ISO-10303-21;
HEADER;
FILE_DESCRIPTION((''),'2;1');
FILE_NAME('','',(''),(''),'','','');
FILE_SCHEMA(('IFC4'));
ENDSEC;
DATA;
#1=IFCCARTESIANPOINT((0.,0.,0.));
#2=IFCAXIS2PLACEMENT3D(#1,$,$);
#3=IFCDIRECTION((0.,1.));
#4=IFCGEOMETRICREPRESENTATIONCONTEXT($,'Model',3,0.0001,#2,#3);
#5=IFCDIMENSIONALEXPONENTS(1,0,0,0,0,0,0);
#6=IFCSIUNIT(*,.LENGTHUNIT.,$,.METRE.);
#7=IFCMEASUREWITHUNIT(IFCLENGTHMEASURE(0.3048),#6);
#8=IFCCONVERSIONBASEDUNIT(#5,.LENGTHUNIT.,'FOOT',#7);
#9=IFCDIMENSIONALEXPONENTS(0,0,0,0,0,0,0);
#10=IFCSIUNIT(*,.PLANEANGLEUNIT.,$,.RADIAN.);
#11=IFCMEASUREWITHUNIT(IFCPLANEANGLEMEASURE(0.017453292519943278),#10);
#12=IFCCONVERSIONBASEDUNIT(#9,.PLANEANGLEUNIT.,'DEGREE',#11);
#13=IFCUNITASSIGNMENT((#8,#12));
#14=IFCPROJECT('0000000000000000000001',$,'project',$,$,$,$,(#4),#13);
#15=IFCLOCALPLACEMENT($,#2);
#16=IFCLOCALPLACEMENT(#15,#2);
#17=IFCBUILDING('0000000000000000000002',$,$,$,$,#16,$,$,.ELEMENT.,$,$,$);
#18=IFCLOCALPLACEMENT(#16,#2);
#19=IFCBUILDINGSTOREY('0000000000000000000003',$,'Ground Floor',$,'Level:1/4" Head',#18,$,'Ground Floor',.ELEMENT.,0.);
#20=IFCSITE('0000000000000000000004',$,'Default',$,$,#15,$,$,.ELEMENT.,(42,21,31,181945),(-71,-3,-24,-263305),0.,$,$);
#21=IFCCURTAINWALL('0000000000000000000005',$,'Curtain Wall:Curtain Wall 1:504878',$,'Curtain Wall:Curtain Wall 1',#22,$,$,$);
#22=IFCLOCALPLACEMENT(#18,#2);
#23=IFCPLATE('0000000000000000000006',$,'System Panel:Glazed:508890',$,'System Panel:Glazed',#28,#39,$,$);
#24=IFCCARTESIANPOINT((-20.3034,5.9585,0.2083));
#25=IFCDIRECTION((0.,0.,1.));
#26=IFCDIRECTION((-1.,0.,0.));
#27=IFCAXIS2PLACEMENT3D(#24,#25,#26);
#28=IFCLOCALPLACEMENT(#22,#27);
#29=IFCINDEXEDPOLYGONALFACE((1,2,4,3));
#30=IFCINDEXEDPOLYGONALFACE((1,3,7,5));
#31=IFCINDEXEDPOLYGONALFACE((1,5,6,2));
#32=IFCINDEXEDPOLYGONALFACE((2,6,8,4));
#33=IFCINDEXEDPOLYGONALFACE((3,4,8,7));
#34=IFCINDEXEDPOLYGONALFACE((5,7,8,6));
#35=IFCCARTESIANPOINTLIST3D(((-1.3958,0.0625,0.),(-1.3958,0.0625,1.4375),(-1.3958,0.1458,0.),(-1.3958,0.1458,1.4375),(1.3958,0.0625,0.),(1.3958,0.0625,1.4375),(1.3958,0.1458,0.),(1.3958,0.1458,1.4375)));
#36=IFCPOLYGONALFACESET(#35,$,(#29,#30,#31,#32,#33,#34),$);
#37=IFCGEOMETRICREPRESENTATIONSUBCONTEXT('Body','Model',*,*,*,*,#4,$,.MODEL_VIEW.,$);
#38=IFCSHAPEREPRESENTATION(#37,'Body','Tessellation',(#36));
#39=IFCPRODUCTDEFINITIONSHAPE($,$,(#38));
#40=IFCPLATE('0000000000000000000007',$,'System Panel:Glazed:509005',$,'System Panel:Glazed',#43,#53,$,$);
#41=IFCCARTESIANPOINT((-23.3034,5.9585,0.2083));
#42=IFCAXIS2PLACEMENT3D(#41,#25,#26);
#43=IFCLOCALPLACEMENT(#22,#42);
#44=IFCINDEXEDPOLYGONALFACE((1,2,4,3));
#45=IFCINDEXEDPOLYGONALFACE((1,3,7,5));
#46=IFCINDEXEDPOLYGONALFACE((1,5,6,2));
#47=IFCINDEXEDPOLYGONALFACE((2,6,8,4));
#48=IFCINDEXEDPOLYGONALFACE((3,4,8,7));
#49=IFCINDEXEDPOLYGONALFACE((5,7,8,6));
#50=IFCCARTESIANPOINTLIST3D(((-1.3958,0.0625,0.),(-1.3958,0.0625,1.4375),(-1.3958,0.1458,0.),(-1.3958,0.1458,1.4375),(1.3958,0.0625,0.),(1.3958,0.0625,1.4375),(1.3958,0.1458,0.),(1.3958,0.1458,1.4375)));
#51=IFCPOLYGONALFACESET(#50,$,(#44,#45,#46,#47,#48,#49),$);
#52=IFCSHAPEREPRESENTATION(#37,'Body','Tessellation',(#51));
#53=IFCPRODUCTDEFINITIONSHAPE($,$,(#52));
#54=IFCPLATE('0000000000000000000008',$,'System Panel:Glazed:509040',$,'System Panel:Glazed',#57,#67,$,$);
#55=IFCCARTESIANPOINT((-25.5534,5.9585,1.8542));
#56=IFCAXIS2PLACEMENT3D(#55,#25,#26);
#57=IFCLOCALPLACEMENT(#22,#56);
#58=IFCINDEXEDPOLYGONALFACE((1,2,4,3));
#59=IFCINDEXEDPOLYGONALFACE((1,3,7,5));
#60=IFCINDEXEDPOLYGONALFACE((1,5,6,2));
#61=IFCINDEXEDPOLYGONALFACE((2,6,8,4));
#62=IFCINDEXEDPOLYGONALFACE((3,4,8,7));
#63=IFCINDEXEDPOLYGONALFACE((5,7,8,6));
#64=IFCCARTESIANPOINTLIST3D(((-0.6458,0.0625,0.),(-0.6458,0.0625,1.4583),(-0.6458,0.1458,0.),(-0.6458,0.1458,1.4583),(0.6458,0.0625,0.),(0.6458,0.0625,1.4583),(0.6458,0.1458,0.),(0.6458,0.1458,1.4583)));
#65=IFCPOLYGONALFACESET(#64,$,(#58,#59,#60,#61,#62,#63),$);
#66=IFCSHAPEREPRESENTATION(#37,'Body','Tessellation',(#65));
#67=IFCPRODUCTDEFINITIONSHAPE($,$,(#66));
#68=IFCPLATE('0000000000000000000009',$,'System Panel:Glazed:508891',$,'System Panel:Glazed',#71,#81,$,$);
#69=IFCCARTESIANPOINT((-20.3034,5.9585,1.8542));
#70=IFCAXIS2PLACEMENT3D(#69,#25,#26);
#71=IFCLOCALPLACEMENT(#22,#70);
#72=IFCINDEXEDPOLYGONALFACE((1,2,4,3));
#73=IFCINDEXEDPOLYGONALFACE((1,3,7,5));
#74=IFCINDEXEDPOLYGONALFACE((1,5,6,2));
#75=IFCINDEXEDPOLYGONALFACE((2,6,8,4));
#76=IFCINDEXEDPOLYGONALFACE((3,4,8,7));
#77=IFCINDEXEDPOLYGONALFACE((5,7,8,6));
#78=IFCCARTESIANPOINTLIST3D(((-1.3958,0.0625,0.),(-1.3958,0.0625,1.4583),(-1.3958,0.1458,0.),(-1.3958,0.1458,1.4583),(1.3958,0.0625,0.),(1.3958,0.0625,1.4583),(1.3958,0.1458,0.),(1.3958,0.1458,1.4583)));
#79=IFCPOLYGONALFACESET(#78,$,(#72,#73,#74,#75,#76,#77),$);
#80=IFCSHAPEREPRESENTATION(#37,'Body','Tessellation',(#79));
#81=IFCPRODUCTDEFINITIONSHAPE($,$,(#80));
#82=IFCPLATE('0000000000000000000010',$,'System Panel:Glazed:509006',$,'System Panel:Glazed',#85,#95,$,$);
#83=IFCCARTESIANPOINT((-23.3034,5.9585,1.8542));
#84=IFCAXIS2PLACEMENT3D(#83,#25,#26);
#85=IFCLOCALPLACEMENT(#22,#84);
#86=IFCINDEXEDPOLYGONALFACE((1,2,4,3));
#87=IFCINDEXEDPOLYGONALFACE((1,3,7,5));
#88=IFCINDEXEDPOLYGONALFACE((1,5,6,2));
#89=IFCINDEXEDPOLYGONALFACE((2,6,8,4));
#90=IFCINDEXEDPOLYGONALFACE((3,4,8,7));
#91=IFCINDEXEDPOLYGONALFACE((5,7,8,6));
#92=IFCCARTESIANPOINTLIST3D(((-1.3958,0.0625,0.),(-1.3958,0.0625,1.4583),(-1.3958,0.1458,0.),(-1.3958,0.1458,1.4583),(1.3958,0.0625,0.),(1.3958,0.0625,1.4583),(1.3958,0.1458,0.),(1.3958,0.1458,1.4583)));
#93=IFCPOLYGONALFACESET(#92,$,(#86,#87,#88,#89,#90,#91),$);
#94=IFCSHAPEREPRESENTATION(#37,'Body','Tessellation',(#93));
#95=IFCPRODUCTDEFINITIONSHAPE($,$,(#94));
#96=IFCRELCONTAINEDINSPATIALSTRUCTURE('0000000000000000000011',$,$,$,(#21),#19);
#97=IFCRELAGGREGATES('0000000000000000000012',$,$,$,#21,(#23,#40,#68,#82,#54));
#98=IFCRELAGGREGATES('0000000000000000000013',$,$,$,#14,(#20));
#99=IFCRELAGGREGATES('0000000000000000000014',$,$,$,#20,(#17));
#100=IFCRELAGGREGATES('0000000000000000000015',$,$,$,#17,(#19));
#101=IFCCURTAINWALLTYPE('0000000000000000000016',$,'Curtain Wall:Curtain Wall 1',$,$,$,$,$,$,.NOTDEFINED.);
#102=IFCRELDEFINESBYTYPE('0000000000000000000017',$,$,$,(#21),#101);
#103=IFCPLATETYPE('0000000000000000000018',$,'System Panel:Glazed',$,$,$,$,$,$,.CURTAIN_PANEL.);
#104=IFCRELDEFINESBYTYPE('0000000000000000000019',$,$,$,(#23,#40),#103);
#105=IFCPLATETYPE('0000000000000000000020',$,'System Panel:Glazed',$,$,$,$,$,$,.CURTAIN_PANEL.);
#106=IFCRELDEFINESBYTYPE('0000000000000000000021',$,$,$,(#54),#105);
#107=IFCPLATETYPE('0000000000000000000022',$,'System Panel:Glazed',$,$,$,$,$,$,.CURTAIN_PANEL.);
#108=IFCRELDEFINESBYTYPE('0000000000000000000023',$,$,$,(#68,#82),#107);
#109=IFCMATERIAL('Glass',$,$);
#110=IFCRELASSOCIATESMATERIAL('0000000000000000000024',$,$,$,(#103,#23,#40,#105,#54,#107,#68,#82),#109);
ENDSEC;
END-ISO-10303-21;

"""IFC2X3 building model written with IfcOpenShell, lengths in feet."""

from ifc_helpers import new_model, entity, si_unit, converted_unit, direction, frame, frame_2d, origin, place, context, subcontext, project, spatial, rectangle, extrude, source, transform, mapped, material, type_object, type_shapes, element, aggregate, save


model = new_model("IFC2X3")

# Units and contexts
model_context = context("Model", 3, precision=0.0001, world=origin(), true_north=direction((0.0, 1.0)))
body_context = subcontext(model_context, "Body", "Model", "MODEL_VIEW")
ifc_project = project(units=[converted_unit("LENGTHUNIT", "FOOT", entity("IfcLengthMeasure", 0.3048), si_unit("LENGTHUNIT", "METRE"), dimensions=[1, 0, 0, 0, 0, 0, 0]), converted_unit("PLANEANGLEUNIT", "DEGREE", entity("IfcPlaneAngleMeasure", 0.017453292519943278), si_unit("PLANEANGLEUNIT", "RADIAN"), dimensions=[0, 0, 0, 0, 0, 0, 0])], contexts=[model_context])

# Site, building, storey
site_placement = place(None, origin())
site = spatial("IfcSite", under=ifc_project, at=site_placement, Name="Default", CompositionType="ELEMENT", RefLatitude=(42, 21, 31, 181945), RefLongitude=(-71, -3, -24, -263305), RefElevation=0.0)
building_placement = place(site_placement, origin())
building = spatial("IfcBuilding", under=site, at=building_placement, CompositionType="ELEMENT")
storey_placement = place(building_placement, origin())
storey = spatial("IfcBuildingStorey", under=building, at=storey_placement, Name="Ground Floor", ObjectType="Level:1/4\" Head", LongName="Ground Floor", CompositionType="ELEMENT", Elevation=0.0)

# Curtain wall, plates
curtain_wall_type = type_object("IfcCurtainWallType", Name="Curtain Wall:Curtain Wall 1", PredefinedType="NOTDEFINED")
curtain_wall_placement = place(storey_placement, origin())
curtain_wall = element("IfcCurtainWall", 1, at=curtain_wall_placement, inside=storey, type_object=curtain_wall_type, Name="Curtain Wall:Curtain Wall 1:504878", ObjectType="Curtain Wall:Curtain Wall 1")
ifc_material_1 = material(Name="Glass")
plate_type_1 = type_object("IfcPlateType", Name="System Panel:Glazed", PredefinedType="CURTAIN_PANEL", material=ifc_material_1)
shared_shape_1 = source(origin(), body_context, "Body", "SweptSolid", [
    extrude(rectangle(XDim=0.0833, YDim=2.7917, at=frame_2d((0.0, 0.0), x_axis=(1.0, 0.0))), frame((0.0, 0.1042, 0.0), z_axis=(0.0, 0.0, 1.0), x_axis=(0.0, 1.0, 0.0)), (0.0, 0.0, 1.0), 1.4375),
])
type_shapes(plate_type_1, [shared_shape_1])
plate_1_placement = place(curtain_wall_placement, frame((-20.3034, 5.9585, 0.2083), z_axis=(0.0, 0.0, 1.0), x_axis=(-1.0, 0.0, 0.0)))
plate_1 = element("IfcPlate", 2, at=plate_1_placement, type_object=plate_type_1, material=ifc_material_1, Name="System Panel:Glazed:508890", ObjectType="System Panel:Glazed", context=body_context, shape_type="MappedRepresentation", body=[
    mapped(shared_shape_1, transform((0.0, 0.0, 0.0), scale=1.0)),
])
plate_2_placement = place(curtain_wall_placement, frame((-23.3034, 5.9585, 0.2083), z_axis=(0.0, 0.0, 1.0), x_axis=(-1.0, 0.0, 0.0)))
plate_2 = element("IfcPlate", 3, at=plate_2_placement, type_object=plate_type_1, material=ifc_material_1, Name="System Panel:Glazed:509005", ObjectType="System Panel:Glazed", context=body_context, shape_type="MappedRepresentation", body=[
    mapped(shared_shape_1, transform((0.0, 0.0, 0.0), scale=1.0)),
])
plate_type_2 = type_object("IfcPlateType", Name="System Panel:Glazed", PredefinedType="CURTAIN_PANEL", material=ifc_material_1)
shared_shape_2 = source(origin(), body_context, "Body", "SweptSolid", [
    extrude(rectangle(XDim=0.0833, YDim=1.2917, at=frame_2d((0.0, 0.0), x_axis=(1.0, 0.0))), frame((0.0, 0.1042, 0.0), z_axis=(0.0, 0.0, 1.0), x_axis=(0.0, 1.0, 0.0)), (0.0, 0.0, 1.0), 1.4583),
])
type_shapes(plate_type_2, [shared_shape_2])
plate_3_placement = place(curtain_wall_placement, frame((-25.5534, 5.9585, 1.8542), z_axis=(0.0, 0.0, 1.0), x_axis=(-1.0, 0.0, 0.0)))
plate_3 = element("IfcPlate", 4, at=plate_3_placement, type_object=plate_type_2, material=ifc_material_1, Name="System Panel:Glazed:509040", ObjectType="System Panel:Glazed", context=body_context, shape_type="MappedRepresentation", body=[
    mapped(shared_shape_2, transform((0.0, 0.0, 0.0), scale=1.0)),
])
plate_type_3 = type_object("IfcPlateType", Name="System Panel:Glazed", PredefinedType="CURTAIN_PANEL", material=ifc_material_1)
shared_shape_3 = source(origin(), body_context, "Body", "SweptSolid", [
    extrude(rectangle(XDim=0.0833, YDim=2.7917, at=frame_2d((0.0, 0.0), x_axis=(1.0, 0.0))), frame((0.0, 0.1042, 0.0), z_axis=(0.0, 0.0, 1.0), x_axis=(0.0, 1.0, 0.0)), (0.0, 0.0, 1.0), 1.4583),
])
type_shapes(plate_type_3, [shared_shape_3])
plate_4_placement = place(curtain_wall_placement, frame((-20.3034, 5.9585, 1.8542), z_axis=(0.0, 0.0, 1.0), x_axis=(-1.0, 0.0, 0.0)))
plate_4 = element("IfcPlate", 5, at=plate_4_placement, type_object=plate_type_3, material=ifc_material_1, Name="System Panel:Glazed:508891", ObjectType="System Panel:Glazed", context=body_context, shape_type="MappedRepresentation", body=[
    mapped(shared_shape_3, transform((0.0, 0.0, 0.0), scale=1.0)),
])
plate_5_placement = place(curtain_wall_placement, frame((-23.3034, 5.9585, 1.8542), z_axis=(0.0, 0.0, 1.0), x_axis=(-1.0, 0.0, 0.0)))
plate_5 = element("IfcPlate", 6, at=plate_5_placement, type_object=plate_type_3, material=ifc_material_1, Name="System Panel:Glazed:509006", ObjectType="System Panel:Glazed", context=body_context, shape_type="MappedRepresentation", body=[
    mapped(shared_shape_3, transform((0.0, 0.0, 0.0), scale=1.0)),
])
aggregate(curtain_wall, [plate_1, plate_2, plate_4, plate_5, plate_3])

save(model, "model.ifc")
